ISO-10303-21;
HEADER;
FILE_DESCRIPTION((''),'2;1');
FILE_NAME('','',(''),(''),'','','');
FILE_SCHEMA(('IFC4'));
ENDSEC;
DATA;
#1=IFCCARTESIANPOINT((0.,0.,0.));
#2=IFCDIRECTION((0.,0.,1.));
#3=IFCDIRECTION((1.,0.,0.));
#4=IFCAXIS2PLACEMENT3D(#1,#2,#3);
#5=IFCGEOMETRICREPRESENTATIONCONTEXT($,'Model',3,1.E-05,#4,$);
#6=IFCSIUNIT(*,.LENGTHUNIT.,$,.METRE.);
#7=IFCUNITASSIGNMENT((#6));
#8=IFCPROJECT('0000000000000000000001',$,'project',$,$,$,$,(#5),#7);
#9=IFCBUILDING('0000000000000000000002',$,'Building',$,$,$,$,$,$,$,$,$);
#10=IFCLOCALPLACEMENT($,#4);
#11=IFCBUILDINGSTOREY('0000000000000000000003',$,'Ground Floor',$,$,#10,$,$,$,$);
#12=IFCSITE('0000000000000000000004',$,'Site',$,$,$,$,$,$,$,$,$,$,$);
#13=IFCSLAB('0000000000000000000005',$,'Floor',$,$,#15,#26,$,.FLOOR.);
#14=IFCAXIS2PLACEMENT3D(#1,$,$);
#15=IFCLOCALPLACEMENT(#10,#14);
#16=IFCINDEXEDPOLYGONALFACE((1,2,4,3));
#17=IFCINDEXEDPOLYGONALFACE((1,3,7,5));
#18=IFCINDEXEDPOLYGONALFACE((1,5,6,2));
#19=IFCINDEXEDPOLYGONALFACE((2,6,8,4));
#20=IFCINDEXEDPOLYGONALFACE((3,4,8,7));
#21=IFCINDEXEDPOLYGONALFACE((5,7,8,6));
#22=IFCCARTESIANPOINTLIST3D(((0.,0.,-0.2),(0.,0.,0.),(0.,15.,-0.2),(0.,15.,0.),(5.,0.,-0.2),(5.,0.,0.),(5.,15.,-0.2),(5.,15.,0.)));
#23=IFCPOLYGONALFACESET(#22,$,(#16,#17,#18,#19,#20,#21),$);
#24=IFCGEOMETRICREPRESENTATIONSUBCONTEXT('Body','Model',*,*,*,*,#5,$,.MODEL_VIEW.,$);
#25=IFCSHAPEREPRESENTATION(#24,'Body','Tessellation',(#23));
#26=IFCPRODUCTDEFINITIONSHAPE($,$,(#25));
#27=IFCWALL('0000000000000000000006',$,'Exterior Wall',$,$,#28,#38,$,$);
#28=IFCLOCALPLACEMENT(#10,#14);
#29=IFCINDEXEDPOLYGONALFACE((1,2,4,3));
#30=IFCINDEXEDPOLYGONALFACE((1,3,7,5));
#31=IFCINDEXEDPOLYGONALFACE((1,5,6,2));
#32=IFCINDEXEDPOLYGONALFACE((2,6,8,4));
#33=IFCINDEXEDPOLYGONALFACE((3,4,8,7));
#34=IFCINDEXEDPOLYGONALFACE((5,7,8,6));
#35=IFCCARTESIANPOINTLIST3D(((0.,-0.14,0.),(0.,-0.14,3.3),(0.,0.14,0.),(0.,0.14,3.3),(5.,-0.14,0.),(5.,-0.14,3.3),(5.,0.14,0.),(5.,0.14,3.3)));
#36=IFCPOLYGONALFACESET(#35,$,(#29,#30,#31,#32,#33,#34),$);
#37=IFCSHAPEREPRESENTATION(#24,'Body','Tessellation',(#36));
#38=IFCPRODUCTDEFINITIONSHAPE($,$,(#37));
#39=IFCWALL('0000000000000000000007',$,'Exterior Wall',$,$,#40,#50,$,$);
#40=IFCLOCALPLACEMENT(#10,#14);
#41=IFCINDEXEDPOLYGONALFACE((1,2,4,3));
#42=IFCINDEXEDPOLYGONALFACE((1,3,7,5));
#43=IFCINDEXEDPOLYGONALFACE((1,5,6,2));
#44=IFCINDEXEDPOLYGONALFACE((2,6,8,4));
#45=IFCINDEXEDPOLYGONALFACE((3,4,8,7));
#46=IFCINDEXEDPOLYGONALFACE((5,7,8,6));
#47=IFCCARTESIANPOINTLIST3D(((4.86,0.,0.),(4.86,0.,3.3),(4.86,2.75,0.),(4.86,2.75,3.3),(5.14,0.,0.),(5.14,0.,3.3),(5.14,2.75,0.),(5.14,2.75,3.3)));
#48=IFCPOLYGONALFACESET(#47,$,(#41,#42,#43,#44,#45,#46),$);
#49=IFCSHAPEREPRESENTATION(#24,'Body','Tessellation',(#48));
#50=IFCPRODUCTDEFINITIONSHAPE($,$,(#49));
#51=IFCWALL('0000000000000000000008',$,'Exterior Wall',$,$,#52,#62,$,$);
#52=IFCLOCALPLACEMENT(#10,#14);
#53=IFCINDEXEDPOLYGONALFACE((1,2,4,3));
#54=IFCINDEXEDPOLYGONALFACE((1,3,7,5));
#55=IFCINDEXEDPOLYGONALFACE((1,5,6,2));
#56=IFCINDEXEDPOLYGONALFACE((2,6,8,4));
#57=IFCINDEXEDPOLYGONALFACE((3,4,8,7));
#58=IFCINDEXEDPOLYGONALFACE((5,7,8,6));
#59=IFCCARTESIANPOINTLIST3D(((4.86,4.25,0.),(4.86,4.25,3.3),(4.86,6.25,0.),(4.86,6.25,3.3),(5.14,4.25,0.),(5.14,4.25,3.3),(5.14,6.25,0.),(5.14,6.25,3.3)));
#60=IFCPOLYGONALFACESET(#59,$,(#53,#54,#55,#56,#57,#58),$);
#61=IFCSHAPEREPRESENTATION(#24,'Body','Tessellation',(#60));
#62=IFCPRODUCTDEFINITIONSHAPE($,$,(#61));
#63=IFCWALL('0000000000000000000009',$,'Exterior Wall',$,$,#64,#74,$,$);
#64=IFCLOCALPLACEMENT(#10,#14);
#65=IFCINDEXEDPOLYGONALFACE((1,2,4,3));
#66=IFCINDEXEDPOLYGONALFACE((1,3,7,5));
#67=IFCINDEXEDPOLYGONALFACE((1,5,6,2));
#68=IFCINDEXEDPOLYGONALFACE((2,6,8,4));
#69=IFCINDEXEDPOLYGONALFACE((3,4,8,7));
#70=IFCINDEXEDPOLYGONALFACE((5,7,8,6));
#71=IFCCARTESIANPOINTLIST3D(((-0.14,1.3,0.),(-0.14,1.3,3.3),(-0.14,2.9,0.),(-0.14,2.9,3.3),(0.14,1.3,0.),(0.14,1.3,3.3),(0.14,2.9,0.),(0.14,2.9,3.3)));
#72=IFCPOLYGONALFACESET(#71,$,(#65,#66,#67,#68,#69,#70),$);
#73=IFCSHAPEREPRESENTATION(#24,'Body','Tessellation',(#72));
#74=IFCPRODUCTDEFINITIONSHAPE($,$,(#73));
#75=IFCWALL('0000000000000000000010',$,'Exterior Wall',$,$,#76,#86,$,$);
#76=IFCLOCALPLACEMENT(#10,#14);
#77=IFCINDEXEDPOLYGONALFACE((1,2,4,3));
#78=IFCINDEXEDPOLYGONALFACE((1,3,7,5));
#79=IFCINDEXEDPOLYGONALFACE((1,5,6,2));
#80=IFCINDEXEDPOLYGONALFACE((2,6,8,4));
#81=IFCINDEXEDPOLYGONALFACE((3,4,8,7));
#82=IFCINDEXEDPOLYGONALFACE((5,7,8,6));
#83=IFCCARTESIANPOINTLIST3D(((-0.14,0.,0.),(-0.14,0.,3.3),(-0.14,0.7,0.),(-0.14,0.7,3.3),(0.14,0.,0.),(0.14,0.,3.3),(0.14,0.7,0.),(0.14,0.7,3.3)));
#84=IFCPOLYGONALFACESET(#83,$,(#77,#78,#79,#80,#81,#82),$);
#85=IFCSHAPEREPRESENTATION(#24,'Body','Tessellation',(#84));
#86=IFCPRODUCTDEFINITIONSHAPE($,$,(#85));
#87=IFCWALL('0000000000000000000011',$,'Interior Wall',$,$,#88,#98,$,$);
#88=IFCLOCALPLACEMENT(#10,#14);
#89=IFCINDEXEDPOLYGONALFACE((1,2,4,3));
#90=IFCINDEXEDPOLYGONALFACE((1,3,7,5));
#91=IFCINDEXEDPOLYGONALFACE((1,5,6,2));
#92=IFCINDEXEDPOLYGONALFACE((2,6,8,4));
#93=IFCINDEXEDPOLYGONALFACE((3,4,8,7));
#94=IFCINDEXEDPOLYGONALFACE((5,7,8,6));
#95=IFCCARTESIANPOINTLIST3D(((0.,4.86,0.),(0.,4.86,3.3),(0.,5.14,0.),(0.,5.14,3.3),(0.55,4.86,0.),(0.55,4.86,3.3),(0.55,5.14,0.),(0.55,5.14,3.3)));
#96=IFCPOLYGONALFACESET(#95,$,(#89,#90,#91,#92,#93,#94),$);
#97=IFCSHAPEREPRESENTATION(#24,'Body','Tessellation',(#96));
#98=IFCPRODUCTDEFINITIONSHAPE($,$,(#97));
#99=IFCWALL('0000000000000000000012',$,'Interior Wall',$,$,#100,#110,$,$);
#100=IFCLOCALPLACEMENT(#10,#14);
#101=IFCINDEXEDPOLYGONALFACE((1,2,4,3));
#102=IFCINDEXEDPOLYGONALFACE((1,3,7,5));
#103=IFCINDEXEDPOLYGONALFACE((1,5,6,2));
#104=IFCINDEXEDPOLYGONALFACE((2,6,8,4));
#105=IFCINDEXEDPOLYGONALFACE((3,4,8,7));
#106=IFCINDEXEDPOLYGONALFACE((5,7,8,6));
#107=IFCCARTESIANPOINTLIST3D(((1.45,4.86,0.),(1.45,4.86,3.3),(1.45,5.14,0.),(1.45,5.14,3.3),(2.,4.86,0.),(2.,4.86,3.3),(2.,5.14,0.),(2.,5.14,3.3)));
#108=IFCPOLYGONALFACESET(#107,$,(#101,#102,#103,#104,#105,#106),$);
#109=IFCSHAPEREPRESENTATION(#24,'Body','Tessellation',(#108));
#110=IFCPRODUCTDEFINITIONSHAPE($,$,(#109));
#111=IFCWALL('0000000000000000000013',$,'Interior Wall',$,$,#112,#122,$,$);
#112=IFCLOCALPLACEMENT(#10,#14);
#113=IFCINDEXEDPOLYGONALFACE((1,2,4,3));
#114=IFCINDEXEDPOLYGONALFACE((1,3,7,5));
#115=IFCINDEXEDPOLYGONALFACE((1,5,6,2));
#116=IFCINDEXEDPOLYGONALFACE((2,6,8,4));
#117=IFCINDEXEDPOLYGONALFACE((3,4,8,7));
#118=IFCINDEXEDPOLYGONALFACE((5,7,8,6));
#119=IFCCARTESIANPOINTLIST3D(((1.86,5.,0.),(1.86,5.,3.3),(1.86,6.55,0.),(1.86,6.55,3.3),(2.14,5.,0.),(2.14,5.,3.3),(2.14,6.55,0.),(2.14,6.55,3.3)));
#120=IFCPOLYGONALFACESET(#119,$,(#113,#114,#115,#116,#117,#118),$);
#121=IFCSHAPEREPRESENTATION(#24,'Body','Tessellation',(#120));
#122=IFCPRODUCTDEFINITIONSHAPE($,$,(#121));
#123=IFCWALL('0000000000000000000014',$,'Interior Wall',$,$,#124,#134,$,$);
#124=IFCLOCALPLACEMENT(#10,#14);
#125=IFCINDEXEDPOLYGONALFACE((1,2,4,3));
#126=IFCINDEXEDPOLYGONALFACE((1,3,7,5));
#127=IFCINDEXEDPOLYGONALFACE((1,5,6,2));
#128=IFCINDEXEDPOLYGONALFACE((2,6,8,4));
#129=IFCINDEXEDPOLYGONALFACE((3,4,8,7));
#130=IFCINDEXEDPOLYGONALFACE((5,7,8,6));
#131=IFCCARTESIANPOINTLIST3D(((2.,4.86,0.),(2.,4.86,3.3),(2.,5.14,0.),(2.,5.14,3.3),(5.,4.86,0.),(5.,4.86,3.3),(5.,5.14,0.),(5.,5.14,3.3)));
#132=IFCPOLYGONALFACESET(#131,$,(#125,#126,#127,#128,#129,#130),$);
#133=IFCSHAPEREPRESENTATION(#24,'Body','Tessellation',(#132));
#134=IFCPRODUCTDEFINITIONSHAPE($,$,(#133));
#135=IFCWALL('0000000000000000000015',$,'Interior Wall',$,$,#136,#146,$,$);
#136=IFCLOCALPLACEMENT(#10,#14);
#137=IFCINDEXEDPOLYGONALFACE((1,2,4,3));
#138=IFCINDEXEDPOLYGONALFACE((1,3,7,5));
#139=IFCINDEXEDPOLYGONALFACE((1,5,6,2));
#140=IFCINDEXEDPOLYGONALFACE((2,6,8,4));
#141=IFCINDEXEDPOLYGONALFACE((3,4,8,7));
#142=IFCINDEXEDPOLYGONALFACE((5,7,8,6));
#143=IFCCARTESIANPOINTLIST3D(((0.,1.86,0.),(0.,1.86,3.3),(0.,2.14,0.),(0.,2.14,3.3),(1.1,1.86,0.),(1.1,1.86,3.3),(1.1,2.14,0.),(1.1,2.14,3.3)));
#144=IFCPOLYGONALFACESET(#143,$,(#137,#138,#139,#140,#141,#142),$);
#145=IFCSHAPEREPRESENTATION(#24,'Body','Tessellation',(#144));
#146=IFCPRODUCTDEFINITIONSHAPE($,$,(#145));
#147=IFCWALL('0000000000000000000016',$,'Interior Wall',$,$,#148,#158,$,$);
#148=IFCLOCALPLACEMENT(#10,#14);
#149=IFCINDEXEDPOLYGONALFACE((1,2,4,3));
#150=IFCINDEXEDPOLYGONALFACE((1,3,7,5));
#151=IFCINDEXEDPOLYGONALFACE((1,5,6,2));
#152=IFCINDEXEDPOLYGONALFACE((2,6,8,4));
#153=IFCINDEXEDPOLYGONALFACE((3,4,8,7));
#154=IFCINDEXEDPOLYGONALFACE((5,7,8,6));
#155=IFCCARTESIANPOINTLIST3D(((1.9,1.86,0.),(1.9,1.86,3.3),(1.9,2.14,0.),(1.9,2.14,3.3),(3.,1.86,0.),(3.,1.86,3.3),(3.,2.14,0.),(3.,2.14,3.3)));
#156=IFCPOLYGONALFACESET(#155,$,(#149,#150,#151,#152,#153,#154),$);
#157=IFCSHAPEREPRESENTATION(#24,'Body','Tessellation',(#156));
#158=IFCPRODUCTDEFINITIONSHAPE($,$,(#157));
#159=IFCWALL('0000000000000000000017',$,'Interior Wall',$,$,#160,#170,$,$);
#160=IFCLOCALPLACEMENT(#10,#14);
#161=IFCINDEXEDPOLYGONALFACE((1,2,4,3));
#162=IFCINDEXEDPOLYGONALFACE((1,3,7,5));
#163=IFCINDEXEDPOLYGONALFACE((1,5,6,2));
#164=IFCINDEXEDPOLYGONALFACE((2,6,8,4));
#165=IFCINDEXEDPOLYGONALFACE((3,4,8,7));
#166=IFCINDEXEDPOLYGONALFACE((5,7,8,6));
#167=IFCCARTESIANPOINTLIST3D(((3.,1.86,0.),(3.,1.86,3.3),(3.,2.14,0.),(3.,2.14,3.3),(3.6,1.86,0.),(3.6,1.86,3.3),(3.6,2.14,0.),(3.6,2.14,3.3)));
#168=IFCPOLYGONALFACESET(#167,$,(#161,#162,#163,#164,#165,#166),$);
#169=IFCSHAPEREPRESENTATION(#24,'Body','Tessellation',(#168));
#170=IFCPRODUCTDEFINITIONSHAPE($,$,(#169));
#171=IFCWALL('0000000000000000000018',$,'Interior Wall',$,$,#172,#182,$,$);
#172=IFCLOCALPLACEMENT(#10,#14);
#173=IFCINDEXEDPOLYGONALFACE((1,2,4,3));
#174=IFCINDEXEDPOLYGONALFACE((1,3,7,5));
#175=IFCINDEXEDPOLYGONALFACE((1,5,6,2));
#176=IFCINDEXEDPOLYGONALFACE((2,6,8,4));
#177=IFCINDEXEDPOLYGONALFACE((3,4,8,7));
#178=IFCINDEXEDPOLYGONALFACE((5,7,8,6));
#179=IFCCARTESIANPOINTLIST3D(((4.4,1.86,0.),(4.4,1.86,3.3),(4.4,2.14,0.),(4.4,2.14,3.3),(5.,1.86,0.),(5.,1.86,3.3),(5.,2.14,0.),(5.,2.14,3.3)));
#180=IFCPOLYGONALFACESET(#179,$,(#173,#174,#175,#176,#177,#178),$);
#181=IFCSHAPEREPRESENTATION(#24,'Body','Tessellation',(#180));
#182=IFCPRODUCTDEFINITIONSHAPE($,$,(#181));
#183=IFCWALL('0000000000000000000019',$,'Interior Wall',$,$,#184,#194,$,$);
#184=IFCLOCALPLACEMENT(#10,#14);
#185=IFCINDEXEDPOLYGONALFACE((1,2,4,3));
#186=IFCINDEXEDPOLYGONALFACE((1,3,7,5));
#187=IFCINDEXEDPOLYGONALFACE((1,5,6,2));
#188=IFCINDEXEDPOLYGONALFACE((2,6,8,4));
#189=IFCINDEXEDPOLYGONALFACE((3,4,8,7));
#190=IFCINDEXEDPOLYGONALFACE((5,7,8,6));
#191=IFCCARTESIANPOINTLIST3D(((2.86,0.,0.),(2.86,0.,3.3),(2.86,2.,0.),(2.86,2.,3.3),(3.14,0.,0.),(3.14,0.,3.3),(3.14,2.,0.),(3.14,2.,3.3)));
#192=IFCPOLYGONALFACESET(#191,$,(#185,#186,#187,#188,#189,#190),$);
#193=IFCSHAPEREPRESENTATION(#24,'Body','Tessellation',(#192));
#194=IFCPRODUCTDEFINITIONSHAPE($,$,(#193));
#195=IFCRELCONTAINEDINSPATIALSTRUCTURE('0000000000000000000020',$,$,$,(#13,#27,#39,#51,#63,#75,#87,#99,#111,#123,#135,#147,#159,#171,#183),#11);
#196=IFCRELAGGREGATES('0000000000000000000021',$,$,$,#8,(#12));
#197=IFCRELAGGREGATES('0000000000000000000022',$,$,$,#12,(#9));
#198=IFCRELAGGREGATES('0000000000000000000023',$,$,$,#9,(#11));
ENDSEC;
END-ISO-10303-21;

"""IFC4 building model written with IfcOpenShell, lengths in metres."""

from ifc_helpers import new_model, si_unit, frame, origin_with_axes, place, context, subcontext, project, spatial, indexed_curve, outline, extrude, element, save


model = new_model("IFC4")

# Units and contexts
model_context = context("Model", 3, precision=1e-05, world=origin_with_axes())
body_context = subcontext(model_context, "Body", "Model", "MODEL_VIEW")
ifc_project = project(units=[si_unit("LENGTHUNIT", "METRE")], contexts=[model_context])

# Site, building, storey
site = spatial("IfcSite", under=ifc_project, Name="Site")
building = spatial("IfcBuilding", under=site, Name="Building")
storey_placement = place(None, origin_with_axes())
storey = spatial("IfcBuildingStorey", under=building, at=storey_placement, Name="Ground Floor")

# Slab
slab_placement = place(storey_placement, frame((0.0, 0.0, -0.2), z_axis=(0.0, 0.0, 1.0), x_axis=(1.0, 0.0, 0.0)))
element("IfcSlab", 1, at=slab_placement, inside=storey, Name="Floor", PredefinedType="FLOOR", context=body_context, shape_type="SweptSolid", body=[
    extrude(outline(indexed_curve([(0.0, 0.0), (5.0, 0.0), (5.0, 15.0), (0.0, 15.0)])), None, (0.0, 0.0, 1.0), 0.2),
])

# Walls
wall_1_placement = place(storey_placement, origin_with_axes())
element("IfcWall", 2, at=wall_1_placement, inside=storey, Name="Exterior Wall", context=body_context, shape_type="SweptSolid", body=[
    extrude(outline(indexed_curve([(0.0, 0.0), (0.0, 0.28), (5.0, 0.28), (5.0, 0.0), (0.0, 0.0)], self_intersect=False)), frame((0.0, -0.14, 0.0), z_axis=(0.0, 0.0, 1.0), x_axis=(1.0, 0.0, 0.0)), (0.0, 0.0, 1.0), 3.3),
])
wall_2_placement = place(storey_placement, frame((5.0, 0.0, 0.0), z_axis=(0.0, 0.0, 1.0), x_axis=(0.0, 1.0, 0.0)))
element("IfcWall", 3, at=wall_2_placement, inside=storey, Name="Exterior Wall", context=body_context, shape_type="SweptSolid", body=[
    extrude(outline(indexed_curve([(0.0, 0.0), (0.0, 0.28), (2.75, 0.28), (2.75, 0.0), (0.0, 0.0)], self_intersect=False)), frame((0.0, -0.14, 0.0), z_axis=(0.0, 0.0, 1.0), x_axis=(1.0, 0.0, 0.0)), (0.0, 0.0, 1.0), 3.3),
])
wall_3_placement = place(storey_placement, frame((5.0, 4.25, 0.0), z_axis=(0.0, 0.0, 1.0), x_axis=(0.0, 1.0, 0.0)))
element("IfcWall", 4, at=wall_3_placement, inside=storey, Name="Exterior Wall", context=body_context, shape_type="SweptSolid", body=[
    extrude(outline(indexed_curve([(0.0, 0.0), (0.0, 0.28), (2.0, 0.28), (2.0, 0.0), (0.0, 0.0)], self_intersect=False)), frame((0.0, -0.14, 0.0), z_axis=(0.0, 0.0, 1.0), x_axis=(1.0, 0.0, 0.0)), (0.0, 0.0, 1.0), 3.3),
])
wall_4_placement = place(storey_placement, frame((0.0, 2.9, 0.0), z_axis=(0.0, 0.0, 1.0), x_axis=(0.0, -1.0, 0.0)))
element("IfcWall", 5, at=wall_4_placement, inside=storey, Name="Exterior Wall", context=body_context, shape_type="SweptSolid", body=[
    extrude(outline(indexed_curve([(0.0, 0.0), (0.0, 0.28), (1.6, 0.28), (1.6, 0.0), (0.0, 0.0)], self_intersect=False)), frame((0.0, -0.14, 0.0), z_axis=(0.0, 0.0, 1.0), x_axis=(1.0, 0.0, 0.0)), (0.0, 0.0, 1.0), 3.3),
])
wall_5_placement = place(storey_placement, frame((0.0, 0.7, 0.0), z_axis=(0.0, 0.0, 1.0), x_axis=(0.0, -1.0, 0.0)))
element("IfcWall", 6, at=wall_5_placement, inside=storey, Name="Exterior Wall", context=body_context, shape_type="SweptSolid", body=[
    extrude(outline(indexed_curve([(0.0, 0.0), (0.0, 0.28), (0.7, 0.28), (0.7, 0.0), (0.0, 0.0)], self_intersect=False)), frame((0.0, -0.14, 0.0), z_axis=(0.0, 0.0, 1.0), x_axis=(1.0, 0.0, 0.0)), (0.0, 0.0, 1.0), 3.3),
])
for number, where, z_axis, x_axis, name in (
    (7, (0.0, 5.0, 0.0), (0.0, 0.0, 1.0), (1.0, 0.0, 0.0), "Interior Wall"),
    (8, (1.45, 5.0, 0.0), (0.0, 0.0, 1.0), (1.0, 0.0, 0.0), "Interior Wall"),
):
    element("IfcWall", number, at=place(storey_placement, frame(where, z_axis=z_axis, x_axis=x_axis)), inside=storey, Name=name, context=body_context, shape_type="SweptSolid", body=[
        extrude(outline(indexed_curve([(0.0, 0.0), (0.0, 0.28), (0.55, 0.28), (0.55, 0.0), (0.0, 0.0)], self_intersect=False)), frame((0.0, -0.14, 0.0), z_axis=(0.0, 0.0, 1.0), x_axis=(1.0, 0.0, 0.0)), (0.0, 0.0, 1.0), 3.3),
    ])
wall_6_placement = place(storey_placement, frame((2.0, 5.0, 0.0), z_axis=(0.0, 0.0, 1.0), x_axis=(0.0, 1.0, 0.0)))
element("IfcWall", 9, at=wall_6_placement, inside=storey, Name="Interior Wall", context=body_context, shape_type="SweptSolid", body=[
    extrude(outline(indexed_curve([(0.0, 0.0), (0.0, 0.28), (1.55, 0.28), (1.55, 0.0), (0.0, 0.0)], self_intersect=False)), frame((0.0, -0.14, 0.0), z_axis=(0.0, 0.0, 1.0), x_axis=(1.0, 0.0, 0.0)), (0.0, 0.0, 1.0), 3.3),
])
wall_7_placement = place(storey_placement, frame((2.0, 5.0, 0.0), z_axis=(0.0, 0.0, 1.0), x_axis=(1.0, 0.0, 0.0)))
element("IfcWall", 10, at=wall_7_placement, inside=storey, Name="Interior Wall", context=body_context, shape_type="SweptSolid", body=[
    extrude(outline(indexed_curve([(0.0, 0.0), (0.0, 0.28), (3.0, 0.28), (3.0, 0.0), (0.0, 0.0)], self_intersect=False)), frame((0.0, -0.14, 0.0), z_axis=(0.0, 0.0, 1.0), x_axis=(1.0, 0.0, 0.0)), (0.0, 0.0, 1.0), 3.3),
])
for number, where, z_axis, x_axis, name in (
    (11, (0.0, 2.0, 0.0), (0.0, 0.0, 1.0), (1.0, 0.0, 0.0), "Interior Wall"),
    (12, (1.9, 2.0, 0.0), (0.0, 0.0, 1.0), (1.0, 0.0, 0.0), "Interior Wall"),
):
    element("IfcWall", number, at=place(storey_placement, frame(where, z_axis=z_axis, x_axis=x_axis)), inside=storey, Name=name, context=body_context, shape_type="SweptSolid", body=[
        extrude(outline(indexed_curve([(0.0, 0.0), (0.0, 0.28), (1.1, 0.28), (1.1, 0.0), (0.0, 0.0)], self_intersect=False)), frame((0.0, -0.14, 0.0), z_axis=(0.0, 0.0, 1.0), x_axis=(1.0, 0.0, 0.0)), (0.0, 0.0, 1.0), 3.3),
    ])
wall_8_placement = place(storey_placement, frame((3.0, 2.0, 0.0), z_axis=(0.0, 0.0, 1.0), x_axis=(1.0, 0.0, 0.0)))
element("IfcWall", 13, at=wall_8_placement, inside=storey, Name="Interior Wall", context=body_context, shape_type="SweptSolid", body=[
    extrude(outline(indexed_curve([(0.0, 0.0), (0.0, 0.28), (0.6, 0.28), (0.6, 0.0), (0.0, 0.0)], self_intersect=False)), frame((0.0, -0.14, 0.0), z_axis=(0.0, 0.0, 1.0), x_axis=(1.0, 0.0, 0.0)), (0.0, 0.0, 1.0), 3.3),
])
wall_9_placement = place(storey_placement, frame((4.4, 2.0, 0.0), z_axis=(0.0, 0.0, 1.0), x_axis=(1.0, 0.0, 0.0)))
element("IfcWall", 14, at=wall_9_placement, inside=storey, Name="Interior Wall", context=body_context, shape_type="SweptSolid", body=[
    extrude(outline(indexed_curve([(0.0, 0.0), (0.0, 0.28), (0.6, 0.28), (0.6, 0.0), (0.0, 0.0)], self_intersect=False)), frame((0.0, -0.14, 0.0), z_axis=(0.0, 0.0, 1.0), x_axis=(1.0, 0.0, 0.0)), (0.0, 0.0, 1.0), 3.3),
])
wall_10_placement = place(storey_placement, frame((3.0, 0.0, 0.0), z_axis=(0.0, 0.0, 1.0), x_axis=(0.0, 1.0, 0.0)))
element("IfcWall", 15, at=wall_10_placement, inside=storey, Name="Interior Wall", context=body_context, shape_type="SweptSolid", body=[
    extrude(outline(indexed_curve([(0.0, 0.0), (0.0, 0.28), (2.0, 0.28), (2.0, 0.0), (0.0, 0.0)], self_intersect=False)), frame((0.0, -0.14, 0.0), z_axis=(0.0, 0.0, 1.0), x_axis=(1.0, 0.0, 0.0)), (0.0, 0.0, 1.0), 3.3),
])

save(model, "model.ifc")
